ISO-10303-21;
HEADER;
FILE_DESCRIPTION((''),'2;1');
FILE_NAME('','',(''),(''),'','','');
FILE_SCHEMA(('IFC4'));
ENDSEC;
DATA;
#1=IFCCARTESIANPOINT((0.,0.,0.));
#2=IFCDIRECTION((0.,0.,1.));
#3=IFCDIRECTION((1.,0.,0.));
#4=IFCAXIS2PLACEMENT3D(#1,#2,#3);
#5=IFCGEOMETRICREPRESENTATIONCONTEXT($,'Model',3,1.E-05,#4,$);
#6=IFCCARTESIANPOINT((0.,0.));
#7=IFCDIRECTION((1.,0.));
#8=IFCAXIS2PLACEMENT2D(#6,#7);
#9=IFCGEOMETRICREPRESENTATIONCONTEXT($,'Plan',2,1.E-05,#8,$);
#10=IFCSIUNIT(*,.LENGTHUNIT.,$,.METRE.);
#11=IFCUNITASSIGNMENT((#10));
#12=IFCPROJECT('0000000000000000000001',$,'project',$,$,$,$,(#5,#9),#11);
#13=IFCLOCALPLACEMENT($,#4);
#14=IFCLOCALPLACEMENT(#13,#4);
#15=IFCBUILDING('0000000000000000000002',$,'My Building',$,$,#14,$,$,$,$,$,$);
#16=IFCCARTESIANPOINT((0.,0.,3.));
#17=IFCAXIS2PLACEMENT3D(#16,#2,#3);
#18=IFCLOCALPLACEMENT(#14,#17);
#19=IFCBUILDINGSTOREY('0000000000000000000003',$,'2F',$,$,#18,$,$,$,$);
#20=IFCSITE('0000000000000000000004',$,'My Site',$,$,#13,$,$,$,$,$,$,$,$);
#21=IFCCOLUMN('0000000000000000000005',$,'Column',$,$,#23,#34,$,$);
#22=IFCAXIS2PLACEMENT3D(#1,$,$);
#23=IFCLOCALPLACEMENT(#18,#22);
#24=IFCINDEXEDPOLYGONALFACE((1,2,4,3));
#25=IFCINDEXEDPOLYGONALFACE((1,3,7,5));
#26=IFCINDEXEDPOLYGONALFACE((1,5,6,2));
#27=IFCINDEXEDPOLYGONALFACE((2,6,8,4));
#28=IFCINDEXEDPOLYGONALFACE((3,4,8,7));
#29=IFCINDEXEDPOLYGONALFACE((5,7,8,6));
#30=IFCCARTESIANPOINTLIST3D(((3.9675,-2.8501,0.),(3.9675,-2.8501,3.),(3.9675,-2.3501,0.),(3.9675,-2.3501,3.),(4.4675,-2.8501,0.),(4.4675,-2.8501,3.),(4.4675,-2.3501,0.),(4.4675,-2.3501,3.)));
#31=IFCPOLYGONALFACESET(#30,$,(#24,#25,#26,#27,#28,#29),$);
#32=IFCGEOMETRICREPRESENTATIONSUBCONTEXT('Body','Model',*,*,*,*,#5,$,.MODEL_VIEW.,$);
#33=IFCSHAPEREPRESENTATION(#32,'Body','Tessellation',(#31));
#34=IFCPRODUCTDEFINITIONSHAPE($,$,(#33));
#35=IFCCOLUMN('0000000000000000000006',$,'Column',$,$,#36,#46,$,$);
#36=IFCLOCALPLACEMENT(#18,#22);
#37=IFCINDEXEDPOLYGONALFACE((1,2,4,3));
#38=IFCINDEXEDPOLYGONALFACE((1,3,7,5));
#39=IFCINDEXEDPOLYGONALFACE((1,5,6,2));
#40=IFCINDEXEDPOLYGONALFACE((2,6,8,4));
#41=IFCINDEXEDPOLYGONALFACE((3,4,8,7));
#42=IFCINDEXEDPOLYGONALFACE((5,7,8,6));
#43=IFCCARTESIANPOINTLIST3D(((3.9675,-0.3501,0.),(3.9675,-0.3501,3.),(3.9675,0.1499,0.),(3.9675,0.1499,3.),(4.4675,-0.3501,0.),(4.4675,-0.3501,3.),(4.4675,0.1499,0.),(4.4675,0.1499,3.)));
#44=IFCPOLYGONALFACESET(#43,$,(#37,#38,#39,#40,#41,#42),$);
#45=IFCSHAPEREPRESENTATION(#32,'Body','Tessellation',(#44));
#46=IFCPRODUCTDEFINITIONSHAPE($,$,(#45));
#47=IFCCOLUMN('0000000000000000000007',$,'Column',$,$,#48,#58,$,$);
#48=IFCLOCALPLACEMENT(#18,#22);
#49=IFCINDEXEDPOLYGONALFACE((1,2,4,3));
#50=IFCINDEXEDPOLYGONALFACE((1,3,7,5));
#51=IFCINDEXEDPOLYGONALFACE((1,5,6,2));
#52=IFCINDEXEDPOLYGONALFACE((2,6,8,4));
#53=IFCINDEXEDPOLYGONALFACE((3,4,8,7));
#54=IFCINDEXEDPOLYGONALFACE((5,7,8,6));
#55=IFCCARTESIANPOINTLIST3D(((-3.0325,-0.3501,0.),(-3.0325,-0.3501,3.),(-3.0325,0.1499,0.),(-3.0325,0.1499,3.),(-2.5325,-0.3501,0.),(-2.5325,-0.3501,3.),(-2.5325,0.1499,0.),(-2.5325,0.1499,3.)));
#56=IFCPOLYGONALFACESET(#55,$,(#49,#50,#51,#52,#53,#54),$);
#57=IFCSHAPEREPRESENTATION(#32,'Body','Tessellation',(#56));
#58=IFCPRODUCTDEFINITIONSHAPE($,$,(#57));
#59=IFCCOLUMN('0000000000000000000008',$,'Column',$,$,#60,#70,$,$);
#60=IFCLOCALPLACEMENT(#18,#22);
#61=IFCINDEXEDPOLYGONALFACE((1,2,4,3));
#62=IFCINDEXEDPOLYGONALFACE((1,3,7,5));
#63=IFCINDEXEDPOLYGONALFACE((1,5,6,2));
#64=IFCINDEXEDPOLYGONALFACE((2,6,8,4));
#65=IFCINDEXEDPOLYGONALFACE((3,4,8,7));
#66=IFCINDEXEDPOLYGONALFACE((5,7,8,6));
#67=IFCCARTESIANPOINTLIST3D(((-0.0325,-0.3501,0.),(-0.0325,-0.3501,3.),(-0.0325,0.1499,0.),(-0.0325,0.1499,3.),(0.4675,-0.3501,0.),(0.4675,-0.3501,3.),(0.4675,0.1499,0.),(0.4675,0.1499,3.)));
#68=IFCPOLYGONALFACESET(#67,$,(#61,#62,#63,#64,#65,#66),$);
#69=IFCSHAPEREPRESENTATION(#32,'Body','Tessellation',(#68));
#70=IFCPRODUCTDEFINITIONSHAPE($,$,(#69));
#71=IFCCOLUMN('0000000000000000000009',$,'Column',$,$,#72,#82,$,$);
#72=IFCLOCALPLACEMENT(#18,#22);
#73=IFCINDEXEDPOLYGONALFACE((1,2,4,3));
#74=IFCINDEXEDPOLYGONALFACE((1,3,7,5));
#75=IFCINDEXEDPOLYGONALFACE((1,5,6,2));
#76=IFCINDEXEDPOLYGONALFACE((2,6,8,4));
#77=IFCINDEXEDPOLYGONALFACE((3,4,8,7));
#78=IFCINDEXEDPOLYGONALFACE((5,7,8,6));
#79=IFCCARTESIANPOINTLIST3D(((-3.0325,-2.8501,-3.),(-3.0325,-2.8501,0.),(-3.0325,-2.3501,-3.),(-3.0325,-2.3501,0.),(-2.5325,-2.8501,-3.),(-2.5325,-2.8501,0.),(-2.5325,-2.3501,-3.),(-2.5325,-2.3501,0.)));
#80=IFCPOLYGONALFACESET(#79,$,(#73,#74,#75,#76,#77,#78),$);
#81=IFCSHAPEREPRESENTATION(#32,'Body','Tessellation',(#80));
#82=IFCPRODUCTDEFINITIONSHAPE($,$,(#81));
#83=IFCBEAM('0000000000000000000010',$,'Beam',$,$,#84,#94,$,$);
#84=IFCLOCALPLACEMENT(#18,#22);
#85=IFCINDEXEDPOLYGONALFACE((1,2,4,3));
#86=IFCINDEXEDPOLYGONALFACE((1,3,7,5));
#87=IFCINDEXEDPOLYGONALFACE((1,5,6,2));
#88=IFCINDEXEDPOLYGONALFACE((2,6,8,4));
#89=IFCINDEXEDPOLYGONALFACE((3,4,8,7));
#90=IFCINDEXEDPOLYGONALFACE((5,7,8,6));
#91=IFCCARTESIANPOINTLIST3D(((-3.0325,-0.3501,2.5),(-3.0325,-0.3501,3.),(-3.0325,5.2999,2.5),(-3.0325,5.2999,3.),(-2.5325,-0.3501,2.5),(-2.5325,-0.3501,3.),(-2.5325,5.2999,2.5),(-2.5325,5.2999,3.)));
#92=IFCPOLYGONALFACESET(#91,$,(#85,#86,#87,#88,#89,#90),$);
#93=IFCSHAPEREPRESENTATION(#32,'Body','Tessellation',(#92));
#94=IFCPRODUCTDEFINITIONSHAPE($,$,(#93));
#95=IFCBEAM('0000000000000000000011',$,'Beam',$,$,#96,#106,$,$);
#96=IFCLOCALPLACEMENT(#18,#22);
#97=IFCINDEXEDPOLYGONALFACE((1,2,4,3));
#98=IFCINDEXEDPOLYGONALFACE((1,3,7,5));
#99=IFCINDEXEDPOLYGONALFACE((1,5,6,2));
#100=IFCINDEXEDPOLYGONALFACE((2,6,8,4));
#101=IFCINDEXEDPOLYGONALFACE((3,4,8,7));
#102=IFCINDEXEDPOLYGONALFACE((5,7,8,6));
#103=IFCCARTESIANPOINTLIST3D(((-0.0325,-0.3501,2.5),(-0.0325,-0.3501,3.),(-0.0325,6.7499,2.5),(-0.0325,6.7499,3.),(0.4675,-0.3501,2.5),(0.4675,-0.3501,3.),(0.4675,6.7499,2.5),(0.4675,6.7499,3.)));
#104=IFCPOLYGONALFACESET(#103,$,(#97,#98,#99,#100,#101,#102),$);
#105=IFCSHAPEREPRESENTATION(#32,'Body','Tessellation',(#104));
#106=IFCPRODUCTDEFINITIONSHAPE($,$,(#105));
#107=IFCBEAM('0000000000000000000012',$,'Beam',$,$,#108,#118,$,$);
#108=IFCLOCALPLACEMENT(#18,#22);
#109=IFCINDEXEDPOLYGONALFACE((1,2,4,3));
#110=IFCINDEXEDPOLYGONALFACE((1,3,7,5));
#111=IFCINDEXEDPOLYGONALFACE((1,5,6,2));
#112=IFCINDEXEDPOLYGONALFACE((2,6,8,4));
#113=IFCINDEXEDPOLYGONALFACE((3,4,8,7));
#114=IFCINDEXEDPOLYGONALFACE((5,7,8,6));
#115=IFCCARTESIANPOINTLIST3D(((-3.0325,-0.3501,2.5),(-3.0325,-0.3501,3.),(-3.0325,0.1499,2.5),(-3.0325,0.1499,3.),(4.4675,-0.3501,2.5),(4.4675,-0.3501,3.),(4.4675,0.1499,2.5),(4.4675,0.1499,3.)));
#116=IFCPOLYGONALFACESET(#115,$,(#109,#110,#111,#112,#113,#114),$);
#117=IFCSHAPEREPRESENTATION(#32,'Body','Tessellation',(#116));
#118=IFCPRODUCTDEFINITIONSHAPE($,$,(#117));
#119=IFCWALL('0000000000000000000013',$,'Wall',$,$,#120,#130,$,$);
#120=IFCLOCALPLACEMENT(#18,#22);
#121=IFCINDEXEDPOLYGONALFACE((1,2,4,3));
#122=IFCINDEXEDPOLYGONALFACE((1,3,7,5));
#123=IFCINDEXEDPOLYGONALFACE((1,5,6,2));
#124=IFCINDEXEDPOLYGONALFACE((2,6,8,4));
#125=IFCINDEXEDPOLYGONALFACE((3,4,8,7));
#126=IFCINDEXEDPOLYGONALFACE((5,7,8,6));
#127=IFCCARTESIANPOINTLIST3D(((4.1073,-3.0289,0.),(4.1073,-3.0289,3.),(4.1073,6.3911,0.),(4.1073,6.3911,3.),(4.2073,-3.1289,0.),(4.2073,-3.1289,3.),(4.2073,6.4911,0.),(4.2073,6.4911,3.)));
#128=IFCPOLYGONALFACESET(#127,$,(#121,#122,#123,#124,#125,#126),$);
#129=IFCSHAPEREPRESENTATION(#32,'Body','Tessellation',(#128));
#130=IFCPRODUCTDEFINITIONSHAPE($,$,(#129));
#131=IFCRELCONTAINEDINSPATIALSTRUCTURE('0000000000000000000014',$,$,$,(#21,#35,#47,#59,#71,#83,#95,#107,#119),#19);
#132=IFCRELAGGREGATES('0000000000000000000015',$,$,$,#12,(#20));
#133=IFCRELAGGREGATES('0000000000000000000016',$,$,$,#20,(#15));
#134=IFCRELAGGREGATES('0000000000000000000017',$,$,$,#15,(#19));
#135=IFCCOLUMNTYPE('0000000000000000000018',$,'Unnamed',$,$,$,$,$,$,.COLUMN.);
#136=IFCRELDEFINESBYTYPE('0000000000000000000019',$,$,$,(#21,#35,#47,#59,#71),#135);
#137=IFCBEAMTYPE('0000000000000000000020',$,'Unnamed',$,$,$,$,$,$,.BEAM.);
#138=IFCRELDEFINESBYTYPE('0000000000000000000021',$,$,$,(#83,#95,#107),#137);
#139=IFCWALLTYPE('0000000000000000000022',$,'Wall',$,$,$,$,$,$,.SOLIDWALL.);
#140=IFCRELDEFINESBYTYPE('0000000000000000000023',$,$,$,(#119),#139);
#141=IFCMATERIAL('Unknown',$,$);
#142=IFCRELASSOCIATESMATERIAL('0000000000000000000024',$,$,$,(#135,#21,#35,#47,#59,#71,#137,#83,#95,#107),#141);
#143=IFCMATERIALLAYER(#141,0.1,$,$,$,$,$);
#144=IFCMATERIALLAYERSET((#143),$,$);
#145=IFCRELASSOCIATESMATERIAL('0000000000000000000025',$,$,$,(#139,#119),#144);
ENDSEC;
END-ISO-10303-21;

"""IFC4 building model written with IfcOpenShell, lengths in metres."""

from ifc_helpers import new_model, si_unit, frame, origin_with_axes, origin_2d_with_axis, place, context, subcontext, project, spatial, line, indexed_curve, rectangle, outline, extrude, material, layer, layer_set, layer_usage, material_profile, profile_set, profile_usage, type_object, element, save


model = new_model("IFC4")

# Units and contexts
model_context = context("Model", 3, precision=1e-05, world=origin_with_axes())
plan_context = context("Plan", 2, precision=1e-05, world=origin_2d_with_axis())
body_context_1 = subcontext(model_context, "Body", "Model", "MODEL_VIEW")
ifc_project = project(units=[si_unit("LENGTHUNIT", "METRE")], contexts=[model_context, plan_context])

# Site, building, storey
site_placement = place(None, origin_with_axes())
site = spatial("IfcSite", under=ifc_project, at=site_placement, Name="My Site")
building_placement = place(site_placement, origin_with_axes())
building = spatial("IfcBuilding", under=site, at=building_placement, Name="My Building")
storey_placement = place(building_placement, frame((0.0, 0.0, 3.0), z_axis=(0.0, 0.0, 1.0), x_axis=(1.0, 0.0, 0.0)))
storey = spatial("IfcBuildingStorey", under=building, at=storey_placement, Name="2F")

# Columns
ifc_material = material(Name="Unknown")
ifc_material_profile_1 = material_profile(ifc_material, rectangle(XDim=0.5, YDim=0.5))
ifc_profile_set_1 = profile_set([ifc_material_profile_1])
ifc_profile_usage_1 = profile_usage(ifc_profile_set_1, cardinal=7)
column_type = type_object("IfcColumnType", Name="Unnamed", PredefinedType="COLUMN", material=ifc_profile_set_1)
column_1_placement = place(storey_placement, frame((4.4675, -2.3501, 0.0), z_axis=(0.0, 0.0, 1.0), x_axis=(1.0, 0.0, 0.0)))
element("IfcColumn", 1, at=column_1_placement, inside=storey, type_object=column_type, material=ifc_profile_usage_1, Name="Column", context=body_context_1, shape_type="SweptSolid", body=[
    extrude(rectangle(XDim=0.5, YDim=0.5), frame((-0.25, -0.25, 0.0), z_axis=(0.0, 0.0, 1.0), x_axis=(1.0, 0.0, 0.0)), (0.0, 0.0, 1.0), 3.0),
])
ifc_profile_usage_2 = profile_usage(ifc_profile_set_1, cardinal=7)
column_2_placement = place(storey_placement, frame((4.4675, 0.1499, 0.0), z_axis=(0.0, 0.0, 1.0), x_axis=(1.0, 0.0, 0.0)))
element("IfcColumn", 2, at=column_2_placement, inside=storey, type_object=column_type, material=ifc_profile_usage_2, Name="Column", context=body_context_1, shape_type="SweptSolid", body=[
    extrude(rectangle(XDim=0.5, YDim=0.5), frame((-0.25, -0.25, 0.0), z_axis=(0.0, 0.0, 1.0), x_axis=(1.0, 0.0, 0.0)), (0.0, 0.0, 1.0), 3.0),
])
ifc_profile_usage_3 = profile_usage(ifc_profile_set_1, cardinal=9)
column_3_placement = place(storey_placement, frame((-3.0325, 0.1499, 0.0), z_axis=(0.0, 0.0, 1.0), x_axis=(1.0, 0.0, 0.0)))
element("IfcColumn", 3, at=column_3_placement, inside=storey, type_object=column_type, material=ifc_profile_usage_3, Name="Column", context=body_context_1, shape_type="SweptSolid", body=[
    extrude(rectangle(XDim=0.5, YDim=0.5), frame((0.25, -0.25, 0.0), z_axis=(0.0, 0.0, 1.0), x_axis=(1.0, 0.0, 0.0)), (0.0, 0.0, 1.0), 3.0),
])
ifc_profile_usage_4 = profile_usage(ifc_profile_set_1, cardinal=9)
column_4_placement = place(storey_placement, frame((-0.0325, 0.1499, 0.0), z_axis=(0.0, 0.0, 1.0), x_axis=(1.0, 0.0, 0.0)))
element("IfcColumn", 4, at=column_4_placement, inside=storey, type_object=column_type, material=ifc_profile_usage_4, Name="Column", context=body_context_1, shape_type="SweptSolid", body=[
    extrude(rectangle(XDim=0.5, YDim=0.5), frame((0.25, -0.25, 0.0), z_axis=(0.0, 0.0, 1.0), x_axis=(1.0, 0.0, 0.0)), (0.0, 0.0, 1.0), 3.0),
])
ifc_profile_usage_5 = profile_usage(ifc_profile_set_1, cardinal=9)
column_5_placement = place(storey_placement, frame((-3.0325, -2.3501, -3.0), z_axis=(0.0, 0.0, 1.0), x_axis=(1.0, 0.0, 0.0)))
element("IfcColumn", 5, at=column_5_placement, inside=storey, type_object=column_type, material=ifc_profile_usage_5, Name="Column", context=body_context_1, shape_type="SweptSolid", body=[
    extrude(rectangle(XDim=0.5, YDim=0.5), frame((0.25, -0.25, 0.0), z_axis=(0.0, 0.0, 1.0), x_axis=(1.0, 0.0, 0.0)), (0.0, 0.0, 1.0), 3.0),
])

# Beams
ifc_material_profile_2 = material_profile(ifc_material, rectangle(XDim=0.5, YDim=0.5))
ifc_profile_set_2 = profile_set([ifc_material_profile_2])
ifc_profile_usage_6 = profile_usage(ifc_profile_set_2, cardinal=9)
beam_type = type_object("IfcBeamType", Name="Unnamed", PredefinedType="BEAM", material=ifc_profile_set_2)
beam_1_placement = place(storey_placement, frame((-2.5325, -0.3501, 3.0), z_axis=(0.0, 1.0, 0.0), x_axis=(-1.0, 0.0, 0.0)))
element("IfcBeam", 6, at=beam_1_placement, inside=storey, type_object=beam_type, material=ifc_profile_usage_6, Name="Beam", context=body_context_1, shape_type="SweptSolid", body=[
    extrude(rectangle(XDim=0.5, YDim=0.5), frame((0.25, -0.25, 0.0), z_axis=(0.0, 0.0, 1.0), x_axis=(1.0, 0.0, 0.0)), (0.0, 0.0, 1.0), 5.65),
])
ifc_profile_usage_7 = profile_usage(ifc_profile_set_2, cardinal=9)
beam_2_placement = place(storey_placement, frame((0.4675, -0.3501, 3.0), z_axis=(0.0, 1.0, 0.0), x_axis=(-1.0, 0.0, 0.0)))
element("IfcBeam", 7, at=beam_2_placement, inside=storey, type_object=beam_type, material=ifc_profile_usage_7, Name="Beam", context=body_context_1, shape_type="SweptSolid", body=[
    extrude(rectangle(XDim=0.5, YDim=0.5), frame((0.25, -0.25, 0.0), z_axis=(0.0, 0.0, 1.0), x_axis=(1.0, 0.0, 0.0)), (0.0, 0.0, 1.0), 7.1),
])
ifc_profile_usage_8 = profile_usage(ifc_profile_set_2, cardinal=9)
beam_3_placement = place(storey_placement, frame((4.4675, 0.1499, 3.0), z_axis=(-1.0, 0.0, 0.0), x_axis=(0.0, -1.0, 0.0)))
element("IfcBeam", 8, at=beam_3_placement, inside=storey, type_object=beam_type, material=ifc_profile_usage_8, Name="Beam", context=body_context_1, shape_type="SweptSolid", body=[
    extrude(rectangle(XDim=0.5, YDim=0.5), frame((0.25, -0.25, 0.0), z_axis=(0.0, 0.0, 1.0), x_axis=(1.0, 0.0, 0.0)), (0.0, 0.0, 1.0), 7.5),
])

# Wall
ifc_layer = layer(ifc_material, 0.1)
ifc_layer_set = layer_set([ifc_layer])
ifc_layer_usage_1 = layer_usage(ifc_layer_set, "AXIS2", "POSITIVE", 0.0)
wall_type = type_object("IfcWallType", Name="Wall", PredefinedType="SOLIDWALL", material=ifc_layer_set)
wall_1_placement = place(storey_placement, frame((4.2073, -3.1289, 0.0), z_axis=(0.0, 0.0, 1.0), x_axis=(0.0, 1.0, 0.0)))
element("IfcWall", 9, at=wall_1_placement, inside=storey, type_object=wall_type, material=ifc_layer_usage_1, Name="Wall", context=body_context_1, shape_type="SweptSolid", body=[
    extrude(outline(indexed_curve([(0.0, 0.0), (0.1, 0.1), (9.52, 0.1), (9.62, 0.0)], segments=[line(1, 2, 3, 4, 1)])), origin_with_axes(), (0.0, 0.0, 1.0), 3.0),
])

save(model, "model.ifc")
